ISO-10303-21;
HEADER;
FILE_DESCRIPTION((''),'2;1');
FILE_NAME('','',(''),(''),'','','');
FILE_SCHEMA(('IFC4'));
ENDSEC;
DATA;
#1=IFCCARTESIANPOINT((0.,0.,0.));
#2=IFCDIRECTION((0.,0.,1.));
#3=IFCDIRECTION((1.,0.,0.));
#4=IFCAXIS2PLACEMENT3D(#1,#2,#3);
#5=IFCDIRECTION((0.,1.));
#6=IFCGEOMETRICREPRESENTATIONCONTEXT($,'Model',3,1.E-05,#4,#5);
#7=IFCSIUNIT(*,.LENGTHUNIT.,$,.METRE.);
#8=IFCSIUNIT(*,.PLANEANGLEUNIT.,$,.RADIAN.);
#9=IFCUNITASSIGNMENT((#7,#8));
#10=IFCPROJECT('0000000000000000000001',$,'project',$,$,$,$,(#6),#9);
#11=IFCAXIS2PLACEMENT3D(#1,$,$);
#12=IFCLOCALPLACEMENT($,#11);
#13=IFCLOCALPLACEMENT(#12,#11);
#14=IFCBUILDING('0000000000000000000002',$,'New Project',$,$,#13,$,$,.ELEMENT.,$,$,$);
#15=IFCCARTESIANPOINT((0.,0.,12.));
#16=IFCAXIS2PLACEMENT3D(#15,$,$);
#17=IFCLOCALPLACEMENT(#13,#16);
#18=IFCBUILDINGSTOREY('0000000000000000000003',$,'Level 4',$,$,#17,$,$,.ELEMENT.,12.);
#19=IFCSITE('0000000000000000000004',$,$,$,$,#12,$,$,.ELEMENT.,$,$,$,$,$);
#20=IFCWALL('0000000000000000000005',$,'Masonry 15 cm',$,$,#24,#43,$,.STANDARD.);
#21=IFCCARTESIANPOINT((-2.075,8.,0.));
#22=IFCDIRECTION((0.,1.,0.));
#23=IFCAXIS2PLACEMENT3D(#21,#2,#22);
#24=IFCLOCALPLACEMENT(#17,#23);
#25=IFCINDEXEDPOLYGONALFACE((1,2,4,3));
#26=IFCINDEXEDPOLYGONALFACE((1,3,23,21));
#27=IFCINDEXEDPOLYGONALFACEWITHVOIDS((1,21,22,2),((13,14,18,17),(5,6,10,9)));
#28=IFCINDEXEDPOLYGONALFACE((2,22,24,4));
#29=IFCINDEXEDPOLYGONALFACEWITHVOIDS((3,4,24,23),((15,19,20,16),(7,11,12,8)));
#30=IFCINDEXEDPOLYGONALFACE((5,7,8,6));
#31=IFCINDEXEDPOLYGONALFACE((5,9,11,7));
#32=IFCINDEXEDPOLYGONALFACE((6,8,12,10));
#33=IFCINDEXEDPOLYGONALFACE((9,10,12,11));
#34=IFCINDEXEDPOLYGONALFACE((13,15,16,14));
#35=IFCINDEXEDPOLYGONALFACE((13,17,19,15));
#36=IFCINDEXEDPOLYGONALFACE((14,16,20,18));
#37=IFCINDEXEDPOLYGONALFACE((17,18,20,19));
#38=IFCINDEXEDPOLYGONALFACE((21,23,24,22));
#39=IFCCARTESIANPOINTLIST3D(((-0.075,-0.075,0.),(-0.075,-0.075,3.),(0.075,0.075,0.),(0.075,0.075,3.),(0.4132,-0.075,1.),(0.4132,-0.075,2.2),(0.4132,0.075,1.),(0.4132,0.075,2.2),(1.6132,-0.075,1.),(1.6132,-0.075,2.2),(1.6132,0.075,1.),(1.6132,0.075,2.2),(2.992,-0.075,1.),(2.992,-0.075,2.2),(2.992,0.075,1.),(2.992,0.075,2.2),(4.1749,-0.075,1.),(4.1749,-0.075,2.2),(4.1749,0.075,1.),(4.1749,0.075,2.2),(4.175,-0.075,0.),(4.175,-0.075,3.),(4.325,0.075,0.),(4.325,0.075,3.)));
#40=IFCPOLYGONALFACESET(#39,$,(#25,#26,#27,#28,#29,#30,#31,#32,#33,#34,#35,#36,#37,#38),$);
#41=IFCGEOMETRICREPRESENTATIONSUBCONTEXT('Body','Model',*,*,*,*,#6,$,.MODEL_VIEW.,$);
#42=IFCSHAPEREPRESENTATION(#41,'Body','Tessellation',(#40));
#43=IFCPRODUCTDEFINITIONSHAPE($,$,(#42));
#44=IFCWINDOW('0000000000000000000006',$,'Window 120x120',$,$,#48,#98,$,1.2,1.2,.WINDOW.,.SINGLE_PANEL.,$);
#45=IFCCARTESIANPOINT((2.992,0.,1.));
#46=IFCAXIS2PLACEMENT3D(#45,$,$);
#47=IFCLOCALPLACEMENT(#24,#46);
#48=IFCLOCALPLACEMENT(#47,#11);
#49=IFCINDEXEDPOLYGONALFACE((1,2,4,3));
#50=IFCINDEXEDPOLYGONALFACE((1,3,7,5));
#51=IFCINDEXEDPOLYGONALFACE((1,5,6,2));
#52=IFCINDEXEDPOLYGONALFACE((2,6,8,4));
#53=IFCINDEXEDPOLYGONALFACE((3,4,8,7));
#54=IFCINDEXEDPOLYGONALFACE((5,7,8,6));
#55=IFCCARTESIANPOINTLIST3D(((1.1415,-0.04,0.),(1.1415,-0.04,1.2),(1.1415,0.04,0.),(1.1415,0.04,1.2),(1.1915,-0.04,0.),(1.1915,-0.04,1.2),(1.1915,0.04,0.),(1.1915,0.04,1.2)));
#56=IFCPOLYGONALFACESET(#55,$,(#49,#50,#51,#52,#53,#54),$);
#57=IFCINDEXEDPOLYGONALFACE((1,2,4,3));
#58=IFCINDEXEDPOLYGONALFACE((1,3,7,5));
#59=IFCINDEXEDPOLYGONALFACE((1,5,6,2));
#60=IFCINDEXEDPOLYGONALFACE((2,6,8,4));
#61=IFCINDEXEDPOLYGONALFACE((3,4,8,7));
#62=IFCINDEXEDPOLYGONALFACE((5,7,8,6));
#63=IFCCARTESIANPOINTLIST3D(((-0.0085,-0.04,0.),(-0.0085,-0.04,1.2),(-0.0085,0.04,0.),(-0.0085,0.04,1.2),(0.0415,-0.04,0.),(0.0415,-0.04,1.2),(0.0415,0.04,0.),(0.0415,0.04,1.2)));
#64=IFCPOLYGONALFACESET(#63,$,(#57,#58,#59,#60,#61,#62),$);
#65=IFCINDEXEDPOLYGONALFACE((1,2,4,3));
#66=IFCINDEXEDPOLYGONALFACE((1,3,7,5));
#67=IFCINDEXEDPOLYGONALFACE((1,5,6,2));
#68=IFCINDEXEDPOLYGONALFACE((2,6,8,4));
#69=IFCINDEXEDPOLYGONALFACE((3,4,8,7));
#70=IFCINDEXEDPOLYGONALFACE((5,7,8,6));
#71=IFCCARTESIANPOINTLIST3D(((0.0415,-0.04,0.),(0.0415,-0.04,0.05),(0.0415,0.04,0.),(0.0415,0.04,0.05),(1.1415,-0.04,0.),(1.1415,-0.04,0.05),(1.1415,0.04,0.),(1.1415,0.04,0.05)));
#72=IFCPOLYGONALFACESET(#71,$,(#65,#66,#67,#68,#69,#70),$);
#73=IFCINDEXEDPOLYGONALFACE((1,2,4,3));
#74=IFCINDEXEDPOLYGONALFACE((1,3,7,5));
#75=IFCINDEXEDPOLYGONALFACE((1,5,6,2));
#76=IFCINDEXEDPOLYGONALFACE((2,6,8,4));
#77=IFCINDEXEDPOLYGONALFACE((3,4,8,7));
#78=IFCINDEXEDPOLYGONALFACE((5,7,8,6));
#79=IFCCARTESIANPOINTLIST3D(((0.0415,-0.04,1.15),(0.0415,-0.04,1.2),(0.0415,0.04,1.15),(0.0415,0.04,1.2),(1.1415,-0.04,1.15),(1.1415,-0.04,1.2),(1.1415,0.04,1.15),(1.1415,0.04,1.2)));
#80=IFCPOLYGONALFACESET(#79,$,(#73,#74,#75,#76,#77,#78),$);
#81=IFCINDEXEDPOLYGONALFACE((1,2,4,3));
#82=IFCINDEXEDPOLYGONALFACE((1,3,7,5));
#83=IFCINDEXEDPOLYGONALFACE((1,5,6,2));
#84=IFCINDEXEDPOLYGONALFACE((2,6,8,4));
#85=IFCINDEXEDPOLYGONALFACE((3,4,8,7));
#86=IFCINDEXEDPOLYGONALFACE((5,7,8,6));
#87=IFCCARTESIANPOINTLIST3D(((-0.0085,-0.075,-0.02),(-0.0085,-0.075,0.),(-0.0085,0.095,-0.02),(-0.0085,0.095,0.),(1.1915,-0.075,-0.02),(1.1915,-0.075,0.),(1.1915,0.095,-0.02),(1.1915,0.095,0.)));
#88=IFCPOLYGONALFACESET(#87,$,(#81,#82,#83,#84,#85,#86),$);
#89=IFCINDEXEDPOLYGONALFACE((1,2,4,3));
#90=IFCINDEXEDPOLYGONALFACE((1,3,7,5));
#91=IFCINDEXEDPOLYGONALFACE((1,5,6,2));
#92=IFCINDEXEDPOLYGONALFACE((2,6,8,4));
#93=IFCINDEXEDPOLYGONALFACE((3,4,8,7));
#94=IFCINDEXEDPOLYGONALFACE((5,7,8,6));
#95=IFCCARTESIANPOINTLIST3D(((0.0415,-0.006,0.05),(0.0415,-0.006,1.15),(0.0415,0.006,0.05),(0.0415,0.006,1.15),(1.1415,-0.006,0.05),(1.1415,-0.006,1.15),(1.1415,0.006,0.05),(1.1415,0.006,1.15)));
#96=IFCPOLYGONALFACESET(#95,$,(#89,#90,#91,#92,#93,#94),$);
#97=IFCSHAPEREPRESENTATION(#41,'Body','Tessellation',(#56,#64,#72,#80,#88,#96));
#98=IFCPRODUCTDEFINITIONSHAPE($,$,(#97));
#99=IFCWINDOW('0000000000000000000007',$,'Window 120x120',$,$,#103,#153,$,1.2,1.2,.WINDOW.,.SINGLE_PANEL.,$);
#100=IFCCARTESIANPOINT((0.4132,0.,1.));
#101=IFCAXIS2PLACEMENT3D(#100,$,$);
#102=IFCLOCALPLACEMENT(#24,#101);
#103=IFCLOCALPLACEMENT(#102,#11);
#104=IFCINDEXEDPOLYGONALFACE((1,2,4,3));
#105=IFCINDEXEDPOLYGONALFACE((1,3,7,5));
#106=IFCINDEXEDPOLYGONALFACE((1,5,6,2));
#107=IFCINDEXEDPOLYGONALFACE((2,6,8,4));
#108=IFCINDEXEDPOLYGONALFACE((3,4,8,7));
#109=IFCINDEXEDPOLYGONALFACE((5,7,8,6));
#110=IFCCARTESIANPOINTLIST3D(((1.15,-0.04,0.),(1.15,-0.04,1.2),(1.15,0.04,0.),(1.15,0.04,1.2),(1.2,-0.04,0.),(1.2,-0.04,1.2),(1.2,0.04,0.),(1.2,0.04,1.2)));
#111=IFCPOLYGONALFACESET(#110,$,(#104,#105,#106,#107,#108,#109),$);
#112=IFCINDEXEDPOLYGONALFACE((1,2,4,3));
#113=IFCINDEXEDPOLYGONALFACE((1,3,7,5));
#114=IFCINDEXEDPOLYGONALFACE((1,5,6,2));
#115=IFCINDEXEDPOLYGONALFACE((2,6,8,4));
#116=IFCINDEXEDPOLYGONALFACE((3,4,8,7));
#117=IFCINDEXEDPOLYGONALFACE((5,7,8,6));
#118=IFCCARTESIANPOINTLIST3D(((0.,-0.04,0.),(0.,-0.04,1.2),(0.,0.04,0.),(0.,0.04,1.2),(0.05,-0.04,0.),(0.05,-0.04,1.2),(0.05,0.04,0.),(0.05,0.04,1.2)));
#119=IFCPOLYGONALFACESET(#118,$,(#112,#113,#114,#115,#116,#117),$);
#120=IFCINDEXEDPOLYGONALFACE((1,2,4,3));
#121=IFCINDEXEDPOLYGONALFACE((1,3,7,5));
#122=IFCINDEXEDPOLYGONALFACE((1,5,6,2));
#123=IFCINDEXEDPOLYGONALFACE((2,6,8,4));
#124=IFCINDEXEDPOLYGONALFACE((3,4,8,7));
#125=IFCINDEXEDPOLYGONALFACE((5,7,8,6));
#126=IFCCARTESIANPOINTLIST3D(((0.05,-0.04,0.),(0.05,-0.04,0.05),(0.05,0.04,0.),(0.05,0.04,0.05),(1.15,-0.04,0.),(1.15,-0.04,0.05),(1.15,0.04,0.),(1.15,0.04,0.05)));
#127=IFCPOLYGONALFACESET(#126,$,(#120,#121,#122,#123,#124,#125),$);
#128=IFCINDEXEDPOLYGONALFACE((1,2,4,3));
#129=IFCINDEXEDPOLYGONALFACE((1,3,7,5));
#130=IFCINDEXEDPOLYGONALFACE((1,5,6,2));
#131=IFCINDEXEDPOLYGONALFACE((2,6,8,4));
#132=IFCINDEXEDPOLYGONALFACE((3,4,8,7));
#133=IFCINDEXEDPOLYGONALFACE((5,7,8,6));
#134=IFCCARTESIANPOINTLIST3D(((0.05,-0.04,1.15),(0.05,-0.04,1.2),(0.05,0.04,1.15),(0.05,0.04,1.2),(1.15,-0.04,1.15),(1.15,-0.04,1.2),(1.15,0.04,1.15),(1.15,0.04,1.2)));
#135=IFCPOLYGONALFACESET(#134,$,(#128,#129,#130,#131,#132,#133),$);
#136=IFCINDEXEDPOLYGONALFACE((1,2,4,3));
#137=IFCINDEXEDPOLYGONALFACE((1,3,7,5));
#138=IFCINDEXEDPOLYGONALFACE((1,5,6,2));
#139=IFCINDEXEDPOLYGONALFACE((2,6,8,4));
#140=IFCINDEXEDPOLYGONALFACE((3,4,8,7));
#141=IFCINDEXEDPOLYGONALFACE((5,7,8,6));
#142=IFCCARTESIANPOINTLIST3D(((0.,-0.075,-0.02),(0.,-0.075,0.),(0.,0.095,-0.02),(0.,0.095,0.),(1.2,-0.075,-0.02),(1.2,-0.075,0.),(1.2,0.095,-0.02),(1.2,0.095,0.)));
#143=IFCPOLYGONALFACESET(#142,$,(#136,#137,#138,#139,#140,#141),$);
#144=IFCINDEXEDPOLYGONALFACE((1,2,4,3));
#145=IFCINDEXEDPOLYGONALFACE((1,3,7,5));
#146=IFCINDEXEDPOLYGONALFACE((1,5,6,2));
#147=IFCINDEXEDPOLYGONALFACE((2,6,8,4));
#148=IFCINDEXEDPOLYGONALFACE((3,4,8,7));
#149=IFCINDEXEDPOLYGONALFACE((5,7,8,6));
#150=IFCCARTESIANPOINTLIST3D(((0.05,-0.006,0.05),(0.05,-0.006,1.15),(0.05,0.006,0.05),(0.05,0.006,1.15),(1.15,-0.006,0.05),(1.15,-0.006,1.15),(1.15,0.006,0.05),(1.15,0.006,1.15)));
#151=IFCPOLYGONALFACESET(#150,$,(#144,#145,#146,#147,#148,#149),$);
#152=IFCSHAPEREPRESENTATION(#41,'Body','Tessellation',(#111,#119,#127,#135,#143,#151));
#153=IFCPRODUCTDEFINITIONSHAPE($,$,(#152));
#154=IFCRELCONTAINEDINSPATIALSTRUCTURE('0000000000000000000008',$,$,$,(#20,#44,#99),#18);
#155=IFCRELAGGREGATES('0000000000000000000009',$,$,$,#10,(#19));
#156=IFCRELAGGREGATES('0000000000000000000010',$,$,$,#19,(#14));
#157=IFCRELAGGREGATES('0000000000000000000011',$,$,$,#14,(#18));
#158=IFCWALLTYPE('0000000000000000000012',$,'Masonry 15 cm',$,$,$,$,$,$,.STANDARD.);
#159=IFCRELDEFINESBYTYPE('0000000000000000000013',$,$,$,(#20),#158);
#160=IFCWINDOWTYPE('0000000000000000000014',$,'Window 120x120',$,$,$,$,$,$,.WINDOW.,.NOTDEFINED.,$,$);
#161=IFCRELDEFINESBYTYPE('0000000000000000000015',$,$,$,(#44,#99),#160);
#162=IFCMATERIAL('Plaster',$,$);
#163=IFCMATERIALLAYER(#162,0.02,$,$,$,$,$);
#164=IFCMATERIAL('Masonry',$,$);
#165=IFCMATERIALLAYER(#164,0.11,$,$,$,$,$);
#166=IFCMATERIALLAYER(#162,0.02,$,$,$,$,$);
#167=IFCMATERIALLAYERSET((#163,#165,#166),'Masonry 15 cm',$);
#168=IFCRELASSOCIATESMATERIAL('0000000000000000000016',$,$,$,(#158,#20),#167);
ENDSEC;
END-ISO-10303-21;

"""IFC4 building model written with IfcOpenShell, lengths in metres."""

from ifc_helpers import new_model, si_unit, direction, frame, frame_2d, origin, origin_with_axes, place, context, subcontext, project, spatial, polyline, rectangle, outline, extrude, material, layer, layer_set, layer_usage, type_object, element, fill, save


model = new_model("IFC4")

# Units and contexts
model_context = context("Model", 3, precision=1e-05, world=origin_with_axes(), true_north=direction((0.0, 1.0)))
body_context = subcontext(model_context, "Body", "Model", "MODEL_VIEW")
ifc_project = project(units=[si_unit("LENGTHUNIT", "METRE"), si_unit("PLANEANGLEUNIT", "RADIAN")], contexts=[model_context])

# Site, building, storey
site_placement = place(None, origin())
site = spatial("IfcSite", under=ifc_project, at=site_placement, CompositionType="ELEMENT")
building_placement = place(site_placement, origin())
building = spatial("IfcBuilding", under=site, at=building_placement, Name="New Project", CompositionType="ELEMENT")
storey_placement = place(building_placement, frame((0.0, 0.0, 12.0)))
storey = spatial("IfcBuildingStorey", under=building, at=storey_placement, Name="Level 4", CompositionType="ELEMENT", Elevation=12.0)

# Shared definitions
ifc_material_1 = material(Name="Plaster")
ifc_layer_1 = layer(ifc_material_1, 0.02)
ifc_material_2 = material(Name="Masonry")
ifc_layer_2 = layer(ifc_material_2, 0.11)
ifc_layer_3 = layer(ifc_material_1, 0.02)
ifc_layer_set_1 = layer_set([ifc_layer_1, ifc_layer_2, ifc_layer_3], Name="Masonry 15 cm")
ifc_layer_usage_1 = layer_usage(ifc_layer_set_1, "AXIS2", "NEGATIVE", 0.075)
wall_type = type_object("IfcWallType", Name="Masonry 15 cm", PredefinedType="STANDARD", material=ifc_layer_set_1)
window_type = type_object("IfcWindowType", Name="Window 120x120", PartitioningType="NOTDEFINED", PredefinedType="WINDOW")

# Wall, openings, windows
wall_1_placement = place(storey_placement, frame((-2.075, 8.0, 0.0), z_axis=(0.0, 0.0, 1.0), x_axis=(0.0, 1.0, 0.0)))
wall_1 = element("IfcWall", 1, at=wall_1_placement, inside=storey, type_object=wall_type, material=ifc_layer_usage_1, Name="Masonry 15 cm", PredefinedType="STANDARD", context=body_context, shape_type="SweptSolid", body=[
    extrude(outline(polyline([(-0.075, -0.075), (4.175, -0.075), (4.325, 0.075), (0.075, 0.075), (-0.075, -0.075)])), origin(), (0.0, 0.0, 1.0), 3.0),
])
opening_1_placement = place(wall_1_placement, frame((2.992, 0.0, 1.0)))
opening_1 = element("IfcOpeningElement", 2, at=opening_1_placement, cuts=wall_1, PredefinedType="OPENING", context=body_context, shape_type="SweptSolid", body=[
    extrude(rectangle(XDim=1.1829, YDim=0.25, at=frame_2d((0.5915, 0.0))), origin(), (0.0, 0.0, 1.0), 1.2),
])
opening_2_placement = place(wall_1_placement, frame((0.4132, 0.0, 1.0)))
opening_2 = element("IfcOpeningElement", 3, at=opening_2_placement, cuts=wall_1, PredefinedType="OPENING", context=body_context, shape_type="SweptSolid", body=[
    extrude(rectangle(XDim=1.2, YDim=0.25, at=frame_2d((0.6, 0.0))), origin(), (0.0, 0.0, 1.0), 1.2),
])
window_1_placement = place(opening_1_placement, origin())
window_1 = element("IfcWindow", 4, at=window_1_placement, inside=storey, type_object=window_type, Name="Window 120x120", OverallHeight=1.2, OverallWidth=1.2, PartitioningType="SINGLE_PANEL", PredefinedType="WINDOW", context=body_context, shape_type="SweptSolid", body=[
    extrude(outline(polyline([(1.1915, 0.04), (1.1415, 0.04), (1.1415, -0.04), (1.1915, -0.04), (1.1915, 0.04)])), origin(), (0.0, 0.0, 1.0), 1.2),
    extrude(outline(polyline([(0.0415, 0.04), (-0.0085, 0.04), (-0.0085, -0.04), (0.0415, -0.04), (0.0415, 0.04)])), origin(), (0.0, 0.0, 1.0), 1.2),
    extrude(outline(polyline([(1.1415, 0.04), (0.0415, 0.04), (0.0415, -0.04), (1.1415, -0.04), (1.1415, 0.04)])), origin(), (0.0, 0.0, 1.0), 0.05),
    extrude(outline(polyline([(1.1415, 0.04), (0.0415, 0.04), (0.0415, -0.04), (1.1415, -0.04), (1.1415, 0.04)])), frame((0.0, 0.0, 1.15)), (0.0, 0.0, 1.0), 0.05),
    extrude(outline(polyline([(1.1915, 0.095), (-0.0085, 0.095), (-0.0085, -0.075), (1.1915, -0.075), (1.1915, 0.095)])), frame((0.0, 0.0, -0.02)), (0.0, 0.0, 1.0), 0.02),
    extrude(outline(polyline([(1.1415, 0.006), (0.0415, 0.006), (0.0415, -0.006), (1.1415, -0.006), (1.1415, 0.006)])), frame((0.0, 0.0, 0.05)), (0.0, 0.0, 1.0), 1.1),
])
fill(opening_1, window_1)
window_2_placement = place(opening_2_placement, origin())
window_2 = element("IfcWindow", 5, at=window_2_placement, inside=storey, type_object=window_type, Name="Window 120x120", OverallHeight=1.2, OverallWidth=1.2, PartitioningType="SINGLE_PANEL", PredefinedType="WINDOW", context=body_context, shape_type="SweptSolid", body=[
    extrude(outline(polyline([(1.2, 0.04), (1.15, 0.04), (1.15, -0.04), (1.2, -0.04), (1.2, 0.04)])), origin(), (0.0, 0.0, 1.0), 1.2),
    extrude(outline(polyline([(0.05, 0.04), (0.0, 0.04), (0.0, -0.04), (0.05, -0.04), (0.05, 0.04)])), origin(), (0.0, 0.0, 1.0), 1.2),
    extrude(outline(polyline([(1.15, 0.04), (0.05, 0.04), (0.05, -0.04), (1.15, -0.04), (1.15, 0.04)])), origin(), (0.0, 0.0, 1.0), 0.05),
    extrude(outline(polyline([(1.15, 0.04), (0.05, 0.04), (0.05, -0.04), (1.15, -0.04), (1.15, 0.04)])), frame((0.0, 0.0, 1.15)), (0.0, 0.0, 1.0), 0.05),
    extrude(outline(polyline([(1.2, 0.095), (0.0, 0.095), (0.0, -0.075), (1.2, -0.075), (1.2, 0.095)])), frame((0.0, 0.0, -0.02)), (0.0, 0.0, 1.0), 0.02),
    extrude(outline(polyline([(1.15, 0.006), (0.05, 0.006), (0.05, -0.006), (1.15, -0.006), (1.15, 0.006)])), frame((0.0, 0.0, 0.05)), (0.0, 0.0, 1.0), 1.1),
])
fill(opening_2, window_2)

save(model, "model.ifc")
